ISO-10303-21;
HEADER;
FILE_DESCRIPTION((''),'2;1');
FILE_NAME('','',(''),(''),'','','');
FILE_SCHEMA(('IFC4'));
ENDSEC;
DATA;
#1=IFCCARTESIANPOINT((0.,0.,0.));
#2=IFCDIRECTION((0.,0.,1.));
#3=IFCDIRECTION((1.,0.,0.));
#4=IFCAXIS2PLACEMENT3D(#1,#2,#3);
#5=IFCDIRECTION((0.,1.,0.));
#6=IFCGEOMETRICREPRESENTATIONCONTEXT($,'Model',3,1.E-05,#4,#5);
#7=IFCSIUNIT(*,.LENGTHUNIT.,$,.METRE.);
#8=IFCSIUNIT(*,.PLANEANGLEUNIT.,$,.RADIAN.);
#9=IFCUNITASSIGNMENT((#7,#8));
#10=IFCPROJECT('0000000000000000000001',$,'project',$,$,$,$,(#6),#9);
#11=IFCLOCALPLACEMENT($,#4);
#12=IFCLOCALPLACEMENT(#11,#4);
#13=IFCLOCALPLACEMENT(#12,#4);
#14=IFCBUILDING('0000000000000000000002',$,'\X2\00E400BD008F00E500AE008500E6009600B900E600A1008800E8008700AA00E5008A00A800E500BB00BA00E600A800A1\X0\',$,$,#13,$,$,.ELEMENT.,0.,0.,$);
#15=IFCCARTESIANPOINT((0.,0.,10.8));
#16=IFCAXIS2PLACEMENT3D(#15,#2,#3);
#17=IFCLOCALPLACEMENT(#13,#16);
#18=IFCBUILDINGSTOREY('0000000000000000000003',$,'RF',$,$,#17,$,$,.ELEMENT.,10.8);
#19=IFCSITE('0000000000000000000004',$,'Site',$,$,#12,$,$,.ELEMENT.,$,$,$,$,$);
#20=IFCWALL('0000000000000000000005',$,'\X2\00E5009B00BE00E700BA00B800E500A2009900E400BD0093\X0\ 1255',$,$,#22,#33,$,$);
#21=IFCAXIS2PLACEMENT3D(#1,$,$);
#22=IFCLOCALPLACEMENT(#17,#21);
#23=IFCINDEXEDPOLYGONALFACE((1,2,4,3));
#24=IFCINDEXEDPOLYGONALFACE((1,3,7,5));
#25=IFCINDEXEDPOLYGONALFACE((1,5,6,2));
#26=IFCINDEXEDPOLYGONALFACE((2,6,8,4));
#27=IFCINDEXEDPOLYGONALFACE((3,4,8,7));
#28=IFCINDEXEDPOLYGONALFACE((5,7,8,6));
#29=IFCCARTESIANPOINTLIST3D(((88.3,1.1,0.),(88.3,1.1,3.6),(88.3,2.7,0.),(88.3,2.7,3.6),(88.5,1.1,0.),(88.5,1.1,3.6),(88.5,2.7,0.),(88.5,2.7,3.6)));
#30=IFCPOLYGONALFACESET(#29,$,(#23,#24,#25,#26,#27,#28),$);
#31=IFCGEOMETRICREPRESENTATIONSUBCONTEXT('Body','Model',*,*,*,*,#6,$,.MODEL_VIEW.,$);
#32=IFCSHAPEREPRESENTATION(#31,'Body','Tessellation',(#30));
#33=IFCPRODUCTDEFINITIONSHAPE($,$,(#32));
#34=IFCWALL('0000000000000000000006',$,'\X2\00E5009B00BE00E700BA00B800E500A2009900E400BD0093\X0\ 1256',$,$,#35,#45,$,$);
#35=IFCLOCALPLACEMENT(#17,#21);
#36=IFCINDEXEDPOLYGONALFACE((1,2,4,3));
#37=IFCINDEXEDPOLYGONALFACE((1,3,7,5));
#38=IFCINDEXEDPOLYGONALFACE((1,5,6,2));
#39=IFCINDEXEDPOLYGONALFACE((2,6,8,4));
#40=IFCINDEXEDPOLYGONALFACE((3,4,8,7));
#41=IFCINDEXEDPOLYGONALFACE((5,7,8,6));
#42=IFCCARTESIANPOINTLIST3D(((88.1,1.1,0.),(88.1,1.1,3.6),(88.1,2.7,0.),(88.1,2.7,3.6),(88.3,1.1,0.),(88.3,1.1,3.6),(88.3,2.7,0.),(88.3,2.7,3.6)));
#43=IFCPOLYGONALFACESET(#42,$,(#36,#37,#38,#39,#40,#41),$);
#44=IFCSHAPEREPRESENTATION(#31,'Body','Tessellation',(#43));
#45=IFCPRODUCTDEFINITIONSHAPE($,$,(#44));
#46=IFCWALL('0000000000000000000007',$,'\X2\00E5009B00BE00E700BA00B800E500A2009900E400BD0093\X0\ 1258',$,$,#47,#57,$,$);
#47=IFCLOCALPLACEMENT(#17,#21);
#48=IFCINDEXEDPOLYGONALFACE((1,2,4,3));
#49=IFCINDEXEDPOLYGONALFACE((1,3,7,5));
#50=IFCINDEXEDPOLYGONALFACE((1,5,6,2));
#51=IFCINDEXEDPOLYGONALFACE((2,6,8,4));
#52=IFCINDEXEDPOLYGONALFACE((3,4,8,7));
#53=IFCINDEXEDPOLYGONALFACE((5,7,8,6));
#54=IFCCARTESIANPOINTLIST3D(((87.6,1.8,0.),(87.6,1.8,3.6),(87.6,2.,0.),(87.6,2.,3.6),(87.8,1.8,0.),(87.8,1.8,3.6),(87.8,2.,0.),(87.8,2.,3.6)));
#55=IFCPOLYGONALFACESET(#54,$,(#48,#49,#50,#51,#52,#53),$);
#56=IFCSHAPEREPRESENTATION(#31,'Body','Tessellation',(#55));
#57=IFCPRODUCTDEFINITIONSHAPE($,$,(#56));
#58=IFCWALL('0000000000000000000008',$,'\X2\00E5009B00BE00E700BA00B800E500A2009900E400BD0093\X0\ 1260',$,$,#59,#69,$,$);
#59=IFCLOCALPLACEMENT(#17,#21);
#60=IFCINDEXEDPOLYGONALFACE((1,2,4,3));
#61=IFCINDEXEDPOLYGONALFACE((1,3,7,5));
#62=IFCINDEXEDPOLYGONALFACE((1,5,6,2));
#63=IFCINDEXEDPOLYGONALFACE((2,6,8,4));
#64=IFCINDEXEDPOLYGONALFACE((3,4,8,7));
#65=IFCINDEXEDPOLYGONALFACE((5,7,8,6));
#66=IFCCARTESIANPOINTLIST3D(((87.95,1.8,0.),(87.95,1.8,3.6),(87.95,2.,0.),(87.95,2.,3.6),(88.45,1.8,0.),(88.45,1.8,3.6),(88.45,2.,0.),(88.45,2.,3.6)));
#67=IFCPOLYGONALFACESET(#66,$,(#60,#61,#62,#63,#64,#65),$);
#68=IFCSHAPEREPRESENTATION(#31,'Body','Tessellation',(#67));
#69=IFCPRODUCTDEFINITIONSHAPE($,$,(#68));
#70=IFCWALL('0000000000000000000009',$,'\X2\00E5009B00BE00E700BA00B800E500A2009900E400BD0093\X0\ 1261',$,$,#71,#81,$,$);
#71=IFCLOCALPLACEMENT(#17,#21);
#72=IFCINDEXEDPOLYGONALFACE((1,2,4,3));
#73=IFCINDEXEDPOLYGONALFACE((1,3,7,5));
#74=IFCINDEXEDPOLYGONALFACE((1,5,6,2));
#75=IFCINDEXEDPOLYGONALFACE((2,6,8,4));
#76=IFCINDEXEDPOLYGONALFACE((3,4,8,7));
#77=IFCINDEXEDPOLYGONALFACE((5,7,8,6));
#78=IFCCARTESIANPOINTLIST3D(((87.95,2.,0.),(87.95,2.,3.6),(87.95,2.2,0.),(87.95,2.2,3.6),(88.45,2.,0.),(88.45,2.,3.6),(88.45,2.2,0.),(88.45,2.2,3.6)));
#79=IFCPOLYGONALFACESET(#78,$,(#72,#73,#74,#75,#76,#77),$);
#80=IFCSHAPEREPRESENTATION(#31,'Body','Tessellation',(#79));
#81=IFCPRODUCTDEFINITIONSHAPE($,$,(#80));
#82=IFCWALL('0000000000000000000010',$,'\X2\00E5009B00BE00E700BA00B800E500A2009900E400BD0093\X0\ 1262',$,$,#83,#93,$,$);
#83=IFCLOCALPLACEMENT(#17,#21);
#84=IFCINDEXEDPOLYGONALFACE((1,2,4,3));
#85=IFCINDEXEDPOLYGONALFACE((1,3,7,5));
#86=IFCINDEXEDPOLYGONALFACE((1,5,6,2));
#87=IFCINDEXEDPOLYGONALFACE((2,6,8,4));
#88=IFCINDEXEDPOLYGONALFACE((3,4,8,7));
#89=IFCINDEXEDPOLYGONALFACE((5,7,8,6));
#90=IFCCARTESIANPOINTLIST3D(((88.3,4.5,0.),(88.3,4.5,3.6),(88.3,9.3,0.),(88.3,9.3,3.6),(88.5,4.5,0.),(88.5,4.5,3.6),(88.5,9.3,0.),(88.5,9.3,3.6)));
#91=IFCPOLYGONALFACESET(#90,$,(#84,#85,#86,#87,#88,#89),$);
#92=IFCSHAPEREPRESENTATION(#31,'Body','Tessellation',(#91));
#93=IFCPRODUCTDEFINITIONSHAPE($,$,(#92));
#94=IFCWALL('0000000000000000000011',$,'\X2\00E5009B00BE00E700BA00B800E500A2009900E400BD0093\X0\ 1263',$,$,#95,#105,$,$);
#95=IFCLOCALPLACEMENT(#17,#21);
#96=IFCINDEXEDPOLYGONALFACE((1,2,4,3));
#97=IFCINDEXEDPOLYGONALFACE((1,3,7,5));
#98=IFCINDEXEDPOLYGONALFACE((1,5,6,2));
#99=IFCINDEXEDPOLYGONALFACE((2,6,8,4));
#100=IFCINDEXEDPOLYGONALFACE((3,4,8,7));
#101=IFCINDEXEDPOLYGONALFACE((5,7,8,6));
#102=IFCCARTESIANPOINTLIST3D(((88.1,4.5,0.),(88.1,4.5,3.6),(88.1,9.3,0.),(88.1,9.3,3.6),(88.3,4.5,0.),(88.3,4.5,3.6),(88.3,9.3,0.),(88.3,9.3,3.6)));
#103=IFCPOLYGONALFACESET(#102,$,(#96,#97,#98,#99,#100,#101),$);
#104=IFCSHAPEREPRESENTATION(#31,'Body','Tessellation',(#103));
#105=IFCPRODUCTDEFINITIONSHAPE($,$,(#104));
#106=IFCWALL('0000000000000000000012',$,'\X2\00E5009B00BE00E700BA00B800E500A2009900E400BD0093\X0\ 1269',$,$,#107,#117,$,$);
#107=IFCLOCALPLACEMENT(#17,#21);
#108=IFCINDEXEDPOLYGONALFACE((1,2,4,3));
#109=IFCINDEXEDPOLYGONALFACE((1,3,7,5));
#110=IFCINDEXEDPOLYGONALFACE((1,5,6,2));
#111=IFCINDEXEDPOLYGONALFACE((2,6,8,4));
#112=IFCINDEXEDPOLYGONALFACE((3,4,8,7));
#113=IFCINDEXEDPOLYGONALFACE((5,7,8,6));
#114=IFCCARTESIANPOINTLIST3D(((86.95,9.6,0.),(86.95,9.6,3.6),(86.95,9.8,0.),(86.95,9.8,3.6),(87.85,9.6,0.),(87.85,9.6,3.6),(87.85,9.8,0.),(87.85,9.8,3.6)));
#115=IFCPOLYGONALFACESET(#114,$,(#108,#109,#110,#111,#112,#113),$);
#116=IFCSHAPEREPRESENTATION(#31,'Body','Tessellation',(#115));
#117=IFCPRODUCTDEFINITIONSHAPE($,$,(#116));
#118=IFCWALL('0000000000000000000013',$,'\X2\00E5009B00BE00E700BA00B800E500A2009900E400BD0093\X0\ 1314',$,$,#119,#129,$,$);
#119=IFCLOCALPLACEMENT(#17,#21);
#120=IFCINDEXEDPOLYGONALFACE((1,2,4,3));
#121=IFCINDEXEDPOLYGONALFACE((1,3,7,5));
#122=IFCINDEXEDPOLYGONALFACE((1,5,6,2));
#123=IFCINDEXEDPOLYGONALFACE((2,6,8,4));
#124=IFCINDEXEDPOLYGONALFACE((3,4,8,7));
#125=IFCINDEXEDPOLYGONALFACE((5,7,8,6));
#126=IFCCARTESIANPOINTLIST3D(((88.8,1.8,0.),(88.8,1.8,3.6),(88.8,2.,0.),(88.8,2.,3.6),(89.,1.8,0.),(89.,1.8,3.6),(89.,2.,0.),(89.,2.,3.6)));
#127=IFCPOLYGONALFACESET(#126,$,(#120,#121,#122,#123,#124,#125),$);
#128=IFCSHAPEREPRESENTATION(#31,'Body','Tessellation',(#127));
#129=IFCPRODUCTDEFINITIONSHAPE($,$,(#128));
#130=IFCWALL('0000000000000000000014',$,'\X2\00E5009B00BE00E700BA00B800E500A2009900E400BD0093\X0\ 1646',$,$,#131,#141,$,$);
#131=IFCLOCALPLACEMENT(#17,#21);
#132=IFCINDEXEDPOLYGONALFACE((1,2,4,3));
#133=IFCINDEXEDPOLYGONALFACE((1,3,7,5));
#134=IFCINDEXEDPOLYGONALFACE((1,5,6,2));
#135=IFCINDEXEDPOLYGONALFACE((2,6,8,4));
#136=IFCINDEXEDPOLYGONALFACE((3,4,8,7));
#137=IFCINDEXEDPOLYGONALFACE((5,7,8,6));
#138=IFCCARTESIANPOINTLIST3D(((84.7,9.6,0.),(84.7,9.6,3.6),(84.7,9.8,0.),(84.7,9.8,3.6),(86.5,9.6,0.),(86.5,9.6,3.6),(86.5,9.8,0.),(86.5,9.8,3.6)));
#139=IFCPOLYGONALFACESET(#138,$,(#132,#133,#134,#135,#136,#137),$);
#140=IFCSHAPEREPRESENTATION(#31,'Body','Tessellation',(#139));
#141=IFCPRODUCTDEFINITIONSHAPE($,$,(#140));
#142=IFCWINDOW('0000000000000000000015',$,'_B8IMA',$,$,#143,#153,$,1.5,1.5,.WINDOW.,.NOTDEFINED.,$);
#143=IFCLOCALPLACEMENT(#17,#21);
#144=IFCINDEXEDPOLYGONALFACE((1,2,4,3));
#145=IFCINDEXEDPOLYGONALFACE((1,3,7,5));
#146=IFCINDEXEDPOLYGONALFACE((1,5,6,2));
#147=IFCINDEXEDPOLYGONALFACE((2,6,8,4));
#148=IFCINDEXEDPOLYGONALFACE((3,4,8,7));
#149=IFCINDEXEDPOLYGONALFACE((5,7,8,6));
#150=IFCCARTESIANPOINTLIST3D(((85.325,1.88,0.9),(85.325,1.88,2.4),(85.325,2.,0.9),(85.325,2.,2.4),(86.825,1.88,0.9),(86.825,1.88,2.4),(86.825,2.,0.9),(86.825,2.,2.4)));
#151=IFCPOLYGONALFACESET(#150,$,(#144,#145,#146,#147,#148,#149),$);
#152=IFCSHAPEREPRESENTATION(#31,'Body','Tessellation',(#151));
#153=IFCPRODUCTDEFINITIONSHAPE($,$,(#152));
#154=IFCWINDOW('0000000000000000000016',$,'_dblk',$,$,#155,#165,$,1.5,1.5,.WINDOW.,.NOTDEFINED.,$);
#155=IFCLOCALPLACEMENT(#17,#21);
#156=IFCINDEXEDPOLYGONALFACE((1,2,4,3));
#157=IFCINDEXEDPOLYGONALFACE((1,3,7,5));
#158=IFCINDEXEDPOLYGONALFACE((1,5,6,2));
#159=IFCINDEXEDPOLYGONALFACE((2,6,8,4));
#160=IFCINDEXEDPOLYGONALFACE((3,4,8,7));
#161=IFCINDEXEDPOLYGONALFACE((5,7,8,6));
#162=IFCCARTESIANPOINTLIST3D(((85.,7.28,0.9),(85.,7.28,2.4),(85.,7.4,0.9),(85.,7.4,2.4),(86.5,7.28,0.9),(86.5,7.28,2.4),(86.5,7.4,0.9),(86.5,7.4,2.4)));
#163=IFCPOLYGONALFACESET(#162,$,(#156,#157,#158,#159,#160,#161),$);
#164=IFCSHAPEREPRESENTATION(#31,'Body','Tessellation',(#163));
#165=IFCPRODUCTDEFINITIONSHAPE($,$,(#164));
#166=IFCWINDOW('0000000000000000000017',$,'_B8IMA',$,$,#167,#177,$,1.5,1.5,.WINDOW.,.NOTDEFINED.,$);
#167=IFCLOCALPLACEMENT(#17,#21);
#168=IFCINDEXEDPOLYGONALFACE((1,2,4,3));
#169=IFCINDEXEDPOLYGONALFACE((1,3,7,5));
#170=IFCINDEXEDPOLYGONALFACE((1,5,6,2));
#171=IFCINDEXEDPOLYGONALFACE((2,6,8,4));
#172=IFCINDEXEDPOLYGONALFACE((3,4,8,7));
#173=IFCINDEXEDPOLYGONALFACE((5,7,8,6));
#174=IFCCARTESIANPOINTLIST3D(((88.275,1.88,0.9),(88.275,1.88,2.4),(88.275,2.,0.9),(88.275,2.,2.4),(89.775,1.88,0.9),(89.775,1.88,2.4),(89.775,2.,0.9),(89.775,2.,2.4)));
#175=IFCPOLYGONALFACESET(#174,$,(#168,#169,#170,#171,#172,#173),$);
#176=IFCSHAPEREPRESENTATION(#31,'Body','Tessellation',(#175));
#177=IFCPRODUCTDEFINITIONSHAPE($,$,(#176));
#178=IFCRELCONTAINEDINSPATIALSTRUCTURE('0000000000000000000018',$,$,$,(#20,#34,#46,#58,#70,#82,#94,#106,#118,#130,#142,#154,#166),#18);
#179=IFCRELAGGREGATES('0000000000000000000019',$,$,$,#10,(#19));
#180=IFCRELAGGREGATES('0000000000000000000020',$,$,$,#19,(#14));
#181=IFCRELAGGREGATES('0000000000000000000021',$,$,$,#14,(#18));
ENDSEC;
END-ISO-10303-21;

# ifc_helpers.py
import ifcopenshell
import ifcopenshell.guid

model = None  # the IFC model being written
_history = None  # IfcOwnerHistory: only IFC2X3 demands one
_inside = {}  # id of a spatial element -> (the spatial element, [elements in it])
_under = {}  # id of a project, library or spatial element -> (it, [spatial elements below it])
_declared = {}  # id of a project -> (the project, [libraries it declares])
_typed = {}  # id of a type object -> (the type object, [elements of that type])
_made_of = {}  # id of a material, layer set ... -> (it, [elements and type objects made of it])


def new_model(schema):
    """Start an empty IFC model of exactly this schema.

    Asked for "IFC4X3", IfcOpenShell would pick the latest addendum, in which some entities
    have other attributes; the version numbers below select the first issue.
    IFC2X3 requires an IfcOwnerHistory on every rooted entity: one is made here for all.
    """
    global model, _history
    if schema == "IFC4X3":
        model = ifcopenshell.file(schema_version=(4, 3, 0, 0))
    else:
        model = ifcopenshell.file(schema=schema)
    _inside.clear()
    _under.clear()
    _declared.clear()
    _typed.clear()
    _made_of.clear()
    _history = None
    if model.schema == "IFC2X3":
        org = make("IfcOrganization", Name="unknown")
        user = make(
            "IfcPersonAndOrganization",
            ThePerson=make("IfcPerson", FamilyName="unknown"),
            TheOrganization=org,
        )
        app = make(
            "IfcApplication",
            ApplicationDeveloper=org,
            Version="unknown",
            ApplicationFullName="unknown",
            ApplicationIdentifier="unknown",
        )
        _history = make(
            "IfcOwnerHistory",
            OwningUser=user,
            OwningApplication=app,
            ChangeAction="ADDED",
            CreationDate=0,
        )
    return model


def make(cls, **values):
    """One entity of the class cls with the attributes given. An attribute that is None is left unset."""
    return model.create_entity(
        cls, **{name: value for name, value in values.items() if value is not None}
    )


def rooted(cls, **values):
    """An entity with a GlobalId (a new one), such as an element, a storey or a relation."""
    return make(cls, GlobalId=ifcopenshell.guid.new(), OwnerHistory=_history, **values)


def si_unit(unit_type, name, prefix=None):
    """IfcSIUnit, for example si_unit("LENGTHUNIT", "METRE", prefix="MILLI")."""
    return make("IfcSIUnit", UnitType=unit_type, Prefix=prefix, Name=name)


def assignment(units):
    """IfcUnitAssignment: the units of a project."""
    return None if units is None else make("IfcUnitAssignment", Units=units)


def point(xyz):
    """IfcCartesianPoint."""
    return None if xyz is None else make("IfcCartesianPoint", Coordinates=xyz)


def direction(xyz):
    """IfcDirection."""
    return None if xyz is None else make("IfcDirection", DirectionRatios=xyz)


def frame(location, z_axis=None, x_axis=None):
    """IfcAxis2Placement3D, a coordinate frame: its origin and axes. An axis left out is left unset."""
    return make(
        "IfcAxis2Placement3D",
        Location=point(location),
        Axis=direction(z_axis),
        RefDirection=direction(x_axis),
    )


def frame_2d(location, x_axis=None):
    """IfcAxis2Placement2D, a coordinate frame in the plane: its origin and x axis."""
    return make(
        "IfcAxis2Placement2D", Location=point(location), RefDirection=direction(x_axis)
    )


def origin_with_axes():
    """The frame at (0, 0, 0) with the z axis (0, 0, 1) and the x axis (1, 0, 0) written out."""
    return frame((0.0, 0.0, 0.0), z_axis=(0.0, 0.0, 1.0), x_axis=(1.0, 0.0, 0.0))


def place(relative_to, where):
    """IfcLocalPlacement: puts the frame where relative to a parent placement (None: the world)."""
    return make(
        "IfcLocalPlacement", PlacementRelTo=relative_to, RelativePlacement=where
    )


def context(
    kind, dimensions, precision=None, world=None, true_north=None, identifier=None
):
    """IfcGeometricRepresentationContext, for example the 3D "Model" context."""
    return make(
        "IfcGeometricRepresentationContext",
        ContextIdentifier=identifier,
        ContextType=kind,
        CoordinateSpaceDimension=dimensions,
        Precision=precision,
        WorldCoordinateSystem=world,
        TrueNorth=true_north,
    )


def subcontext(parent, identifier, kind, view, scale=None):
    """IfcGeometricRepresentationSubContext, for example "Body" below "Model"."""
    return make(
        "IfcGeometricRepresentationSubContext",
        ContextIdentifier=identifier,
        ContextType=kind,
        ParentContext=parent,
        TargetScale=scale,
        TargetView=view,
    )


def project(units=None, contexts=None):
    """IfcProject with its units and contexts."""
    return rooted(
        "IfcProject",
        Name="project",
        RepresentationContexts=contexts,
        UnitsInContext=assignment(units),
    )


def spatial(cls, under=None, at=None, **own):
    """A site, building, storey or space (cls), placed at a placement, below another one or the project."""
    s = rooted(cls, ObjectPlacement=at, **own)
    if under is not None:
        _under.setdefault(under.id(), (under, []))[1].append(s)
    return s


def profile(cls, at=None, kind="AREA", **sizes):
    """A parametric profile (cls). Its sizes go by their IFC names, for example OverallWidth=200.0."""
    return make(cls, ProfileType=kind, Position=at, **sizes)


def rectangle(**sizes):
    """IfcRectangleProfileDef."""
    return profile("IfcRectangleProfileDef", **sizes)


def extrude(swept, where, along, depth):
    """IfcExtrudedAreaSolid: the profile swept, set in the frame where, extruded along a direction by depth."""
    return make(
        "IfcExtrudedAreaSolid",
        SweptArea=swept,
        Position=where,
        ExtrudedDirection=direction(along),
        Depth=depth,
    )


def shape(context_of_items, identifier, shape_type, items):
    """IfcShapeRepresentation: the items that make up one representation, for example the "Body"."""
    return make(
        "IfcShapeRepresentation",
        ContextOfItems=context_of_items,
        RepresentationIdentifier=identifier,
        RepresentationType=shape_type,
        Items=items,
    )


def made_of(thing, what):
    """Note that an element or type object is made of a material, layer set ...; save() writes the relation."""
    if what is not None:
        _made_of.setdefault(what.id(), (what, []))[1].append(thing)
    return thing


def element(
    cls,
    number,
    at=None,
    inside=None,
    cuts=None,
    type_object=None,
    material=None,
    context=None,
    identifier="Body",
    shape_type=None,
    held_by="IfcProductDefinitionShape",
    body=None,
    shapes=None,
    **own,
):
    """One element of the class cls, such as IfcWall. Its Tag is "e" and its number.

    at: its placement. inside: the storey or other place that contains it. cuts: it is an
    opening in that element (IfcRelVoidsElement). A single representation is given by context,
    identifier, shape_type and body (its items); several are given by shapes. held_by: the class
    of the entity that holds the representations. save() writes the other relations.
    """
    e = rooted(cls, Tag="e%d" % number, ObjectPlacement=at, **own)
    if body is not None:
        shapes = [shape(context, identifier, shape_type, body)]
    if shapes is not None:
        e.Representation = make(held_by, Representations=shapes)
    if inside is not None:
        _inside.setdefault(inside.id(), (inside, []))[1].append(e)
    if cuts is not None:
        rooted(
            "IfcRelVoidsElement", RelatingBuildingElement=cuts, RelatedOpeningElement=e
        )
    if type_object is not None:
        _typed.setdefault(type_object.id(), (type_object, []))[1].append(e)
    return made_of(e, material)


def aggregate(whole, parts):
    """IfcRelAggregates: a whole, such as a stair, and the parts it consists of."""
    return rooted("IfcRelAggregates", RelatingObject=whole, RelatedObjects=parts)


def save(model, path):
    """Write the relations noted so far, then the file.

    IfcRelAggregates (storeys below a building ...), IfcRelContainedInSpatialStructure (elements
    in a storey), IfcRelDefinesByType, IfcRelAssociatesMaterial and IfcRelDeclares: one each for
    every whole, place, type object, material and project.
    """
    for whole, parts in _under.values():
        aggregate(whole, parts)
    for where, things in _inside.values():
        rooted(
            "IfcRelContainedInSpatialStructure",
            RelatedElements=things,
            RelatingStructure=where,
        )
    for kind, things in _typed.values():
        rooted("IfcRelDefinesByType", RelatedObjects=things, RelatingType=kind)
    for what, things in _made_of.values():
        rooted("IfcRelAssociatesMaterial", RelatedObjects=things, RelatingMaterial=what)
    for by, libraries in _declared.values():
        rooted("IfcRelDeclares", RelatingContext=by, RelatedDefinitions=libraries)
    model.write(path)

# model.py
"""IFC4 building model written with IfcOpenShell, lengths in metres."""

from ifc_helpers import new_model, si_unit, direction, frame, frame_2d, origin_with_axes, place, context, subcontext, project, spatial, rectangle, extrude, element, save


model = new_model("IFC4")

# Units and contexts
model_context = context("Model", 3, precision=1e-05, world=origin_with_axes(), true_north=direction((0.0, 1.0, 0.0)))
body_context = subcontext(model_context, "Body", "Model", "MODEL_VIEW")
ifc_project = project(units=[si_unit("LENGTHUNIT", "METRE"), si_unit("PLANEANGLEUNIT", "RADIAN")], contexts=[model_context])

# Site, building, storey
placement = place(None, origin_with_axes())
site_placement = place(placement, origin_with_axes())
site = spatial("IfcSite", under=ifc_project, at=site_placement, Name="Site", CompositionType="ELEMENT")
building_placement = place(site_placement, origin_with_axes())
building = spatial("IfcBuilding", under=site, at=building_placement, Name="ä½\u008få®\u0085æ\u0096¹æ¡\u0088è\u0087ªå\u008a¨å»ºæ¨¡", CompositionType="ELEMENT", ElevationOfRefHeight=0.0, ElevationOfTerrain=0.0)
storey_placement = place(building_placement, frame((0.0, 0.0, 10.8), z_axis=(0.0, 0.0, 1.0), x_axis=(1.0, 0.0, 0.0)))
storey = spatial("IfcBuildingStorey", under=building, at=storey_placement, Name="RF", CompositionType="ELEMENT", Elevation=10.8)

# Walls
for number, where, z_axis, x_axis, name in (
    (1, (88.4, 1.9, 0.0), (0.0, 0.0, 1.0), (0.0, -1.0, 0.0), "å\u009b¾çº¸å¢\u0099ä½\u0093 1255"),
    (2, (88.2, 1.9, 0.0), (0.0, 0.0, 1.0), (0.0, -1.0, 0.0), "å\u009b¾çº¸å¢\u0099ä½\u0093 1256"),
):
    element("IfcWall", number, at=place(storey_placement, frame(where, z_axis=z_axis, x_axis=x_axis)), inside=storey, Name=name, context=body_context, shape_type="SweptSolid", body=[
        extrude(rectangle(XDim=1.6, YDim=0.2, at=frame_2d((0.0, 0.0), x_axis=(1.0, 0.0, 0.0))), frame((0.0, 0.0, 0.0), z_axis=(0.0, 0.0, 1.0)), (0.0, 0.0, 1.0), 3.6),
    ])
wall_1_placement = place(storey_placement, frame((87.7, 1.9, 0.0), z_axis=(0.0, 0.0, 1.0), x_axis=(0.0, 1.0, 0.0)))
element("IfcWall", 3, at=wall_1_placement, inside=storey, Name="å\u009b¾çº¸å¢\u0099ä½\u0093 1258", context=body_context, shape_type="SweptSolid", body=[
    extrude(rectangle(XDim=0.2, YDim=0.2, at=frame_2d((0.0, 0.0), x_axis=(1.0, 0.0, 0.0))), frame((0.0, 0.0, 0.0), z_axis=(0.0, 0.0, 1.0)), (0.0, 0.0, 1.0), 3.6),
])
for number, where, z_axis, x_axis, name in (
    (4, (88.2, 1.9, 0.0), (0.0, 0.0, 1.0), (-1.0, 0.0, 0.0), "å\u009b¾çº¸å¢\u0099ä½\u0093 1260"),
    (5, (88.2, 2.1, 0.0), (0.0, 0.0, 1.0), (-1.0, 0.0, 0.0), "å\u009b¾çº¸å¢\u0099ä½\u0093 1261"),
):
    element("IfcWall", number, at=place(storey_placement, frame(where, z_axis=z_axis, x_axis=x_axis)), inside=storey, Name=name, context=body_context, shape_type="SweptSolid", body=[
        extrude(rectangle(XDim=0.5, YDim=0.2, at=frame_2d((0.0, 0.0), x_axis=(1.0, 0.0, 0.0))), frame((0.0, 0.0, 0.0), z_axis=(0.0, 0.0, 1.0)), (0.0, 0.0, 1.0), 3.6),
    ])
for number, where, z_axis, x_axis, name in (
    (6, (88.4, 6.9, 0.0), (0.0, 0.0, 1.0), (0.0, -1.0, 0.0), "å\u009b¾çº¸å¢\u0099ä½\u0093 1262"),
    (7, (88.2, 6.9, 0.0), (0.0, 0.0, 1.0), (0.0, -1.0, 0.0), "å\u009b¾çº¸å¢\u0099ä½\u0093 1263"),
):
    element("IfcWall", number, at=place(storey_placement, frame(where, z_axis=z_axis, x_axis=x_axis)), inside=storey, Name=name, context=body_context, shape_type="SweptSolid", body=[
        extrude(rectangle(XDim=4.8, YDim=0.2, at=frame_2d((0.0, 0.0), x_axis=(1.0, 0.0, 0.0))), frame((0.0, 0.0, 0.0), z_axis=(0.0, 0.0, 1.0)), (0.0, 0.0, 1.0), 3.6),
    ])
wall_2_placement = place(storey_placement, frame((87.4, 9.7, 0.0), z_axis=(0.0, 0.0, 1.0), x_axis=(1.0, 0.0, 0.0)))
element("IfcWall", 8, at=wall_2_placement, inside=storey, Name="å\u009b¾çº¸å¢\u0099ä½\u0093 1269", context=body_context, shape_type="SweptSolid", body=[
    extrude(rectangle(XDim=0.9, YDim=0.2, at=frame_2d((0.0, 0.0), x_axis=(1.0, 0.0, 0.0))), frame((0.0, 0.0, 0.0), z_axis=(0.0, 0.0, 1.0)), (0.0, 0.0, 1.0), 3.6),
])
wall_3_placement = place(storey_placement, frame((88.9, 1.9, 0.0), z_axis=(0.0, 0.0, 1.0), x_axis=(0.0, 1.0, 0.0)))
element("IfcWall", 9, at=wall_3_placement, inside=storey, Name="å\u009b¾çº¸å¢\u0099ä½\u0093 1314", context=body_context, shape_type="SweptSolid", body=[
    extrude(rectangle(XDim=0.2, YDim=0.2, at=frame_2d((0.0, 0.0), x_axis=(1.0, 0.0, 0.0))), frame((0.0, 0.0, 0.0), z_axis=(0.0, 0.0, 1.0)), (0.0, 0.0, 1.0), 3.6),
])
wall_4_placement = place(storey_placement, frame((85.6, 9.7, 0.0), z_axis=(0.0, 0.0, 1.0), x_axis=(1.0, 0.0, 0.0)))
element("IfcWall", 10, at=wall_4_placement, inside=storey, Name="å\u009b¾çº¸å¢\u0099ä½\u0093 1646", context=body_context, shape_type="SweptSolid", body=[
    extrude(rectangle(XDim=1.8, YDim=0.2, at=frame_2d((0.0, 0.0), x_axis=(1.0, 0.0, 0.0))), frame((0.0, 0.0, 0.0), z_axis=(0.0, 0.0, 1.0)), (0.0, 0.0, 1.0), 3.6),
])

# Windows
for number, where, z_axis, x_axis, name in (
    (11, (86.075, 1.94, 0.9), (0.0, 0.0, 1.0), (1.0, 0.0, 0.0), "_B8IMA"),
    (12, (85.75, 7.34, 0.9), (0.0, 0.0, 1.0), (1.0, 0.0, 0.0), "_dblk"),
    (13, (89.025, 1.94, 0.9), (0.0, 0.0, 1.0), (1.0, 0.0, 0.0), "_B8IMA"),
):
    element("IfcWindow", number, at=place(storey_placement, frame(where, z_axis=z_axis, x_axis=x_axis)), inside=storey, Name=name, OverallHeight=1.5, OverallWidth=1.5, PartitioningType="NOTDEFINED", PredefinedType="WINDOW", context=body_context, shape_type="SweptSolid", body=[
        extrude(rectangle(XDim=1.5, YDim=0.12, at=frame_2d((0.0, 0.0), x_axis=(1.0, 0.0, 0.0))), frame((0.0, 0.0, 0.0), z_axis=(0.0, 0.0, 1.0)), (0.0, 0.0, 1.0), 1.5),
    ])

save(model, "model.ifc")
